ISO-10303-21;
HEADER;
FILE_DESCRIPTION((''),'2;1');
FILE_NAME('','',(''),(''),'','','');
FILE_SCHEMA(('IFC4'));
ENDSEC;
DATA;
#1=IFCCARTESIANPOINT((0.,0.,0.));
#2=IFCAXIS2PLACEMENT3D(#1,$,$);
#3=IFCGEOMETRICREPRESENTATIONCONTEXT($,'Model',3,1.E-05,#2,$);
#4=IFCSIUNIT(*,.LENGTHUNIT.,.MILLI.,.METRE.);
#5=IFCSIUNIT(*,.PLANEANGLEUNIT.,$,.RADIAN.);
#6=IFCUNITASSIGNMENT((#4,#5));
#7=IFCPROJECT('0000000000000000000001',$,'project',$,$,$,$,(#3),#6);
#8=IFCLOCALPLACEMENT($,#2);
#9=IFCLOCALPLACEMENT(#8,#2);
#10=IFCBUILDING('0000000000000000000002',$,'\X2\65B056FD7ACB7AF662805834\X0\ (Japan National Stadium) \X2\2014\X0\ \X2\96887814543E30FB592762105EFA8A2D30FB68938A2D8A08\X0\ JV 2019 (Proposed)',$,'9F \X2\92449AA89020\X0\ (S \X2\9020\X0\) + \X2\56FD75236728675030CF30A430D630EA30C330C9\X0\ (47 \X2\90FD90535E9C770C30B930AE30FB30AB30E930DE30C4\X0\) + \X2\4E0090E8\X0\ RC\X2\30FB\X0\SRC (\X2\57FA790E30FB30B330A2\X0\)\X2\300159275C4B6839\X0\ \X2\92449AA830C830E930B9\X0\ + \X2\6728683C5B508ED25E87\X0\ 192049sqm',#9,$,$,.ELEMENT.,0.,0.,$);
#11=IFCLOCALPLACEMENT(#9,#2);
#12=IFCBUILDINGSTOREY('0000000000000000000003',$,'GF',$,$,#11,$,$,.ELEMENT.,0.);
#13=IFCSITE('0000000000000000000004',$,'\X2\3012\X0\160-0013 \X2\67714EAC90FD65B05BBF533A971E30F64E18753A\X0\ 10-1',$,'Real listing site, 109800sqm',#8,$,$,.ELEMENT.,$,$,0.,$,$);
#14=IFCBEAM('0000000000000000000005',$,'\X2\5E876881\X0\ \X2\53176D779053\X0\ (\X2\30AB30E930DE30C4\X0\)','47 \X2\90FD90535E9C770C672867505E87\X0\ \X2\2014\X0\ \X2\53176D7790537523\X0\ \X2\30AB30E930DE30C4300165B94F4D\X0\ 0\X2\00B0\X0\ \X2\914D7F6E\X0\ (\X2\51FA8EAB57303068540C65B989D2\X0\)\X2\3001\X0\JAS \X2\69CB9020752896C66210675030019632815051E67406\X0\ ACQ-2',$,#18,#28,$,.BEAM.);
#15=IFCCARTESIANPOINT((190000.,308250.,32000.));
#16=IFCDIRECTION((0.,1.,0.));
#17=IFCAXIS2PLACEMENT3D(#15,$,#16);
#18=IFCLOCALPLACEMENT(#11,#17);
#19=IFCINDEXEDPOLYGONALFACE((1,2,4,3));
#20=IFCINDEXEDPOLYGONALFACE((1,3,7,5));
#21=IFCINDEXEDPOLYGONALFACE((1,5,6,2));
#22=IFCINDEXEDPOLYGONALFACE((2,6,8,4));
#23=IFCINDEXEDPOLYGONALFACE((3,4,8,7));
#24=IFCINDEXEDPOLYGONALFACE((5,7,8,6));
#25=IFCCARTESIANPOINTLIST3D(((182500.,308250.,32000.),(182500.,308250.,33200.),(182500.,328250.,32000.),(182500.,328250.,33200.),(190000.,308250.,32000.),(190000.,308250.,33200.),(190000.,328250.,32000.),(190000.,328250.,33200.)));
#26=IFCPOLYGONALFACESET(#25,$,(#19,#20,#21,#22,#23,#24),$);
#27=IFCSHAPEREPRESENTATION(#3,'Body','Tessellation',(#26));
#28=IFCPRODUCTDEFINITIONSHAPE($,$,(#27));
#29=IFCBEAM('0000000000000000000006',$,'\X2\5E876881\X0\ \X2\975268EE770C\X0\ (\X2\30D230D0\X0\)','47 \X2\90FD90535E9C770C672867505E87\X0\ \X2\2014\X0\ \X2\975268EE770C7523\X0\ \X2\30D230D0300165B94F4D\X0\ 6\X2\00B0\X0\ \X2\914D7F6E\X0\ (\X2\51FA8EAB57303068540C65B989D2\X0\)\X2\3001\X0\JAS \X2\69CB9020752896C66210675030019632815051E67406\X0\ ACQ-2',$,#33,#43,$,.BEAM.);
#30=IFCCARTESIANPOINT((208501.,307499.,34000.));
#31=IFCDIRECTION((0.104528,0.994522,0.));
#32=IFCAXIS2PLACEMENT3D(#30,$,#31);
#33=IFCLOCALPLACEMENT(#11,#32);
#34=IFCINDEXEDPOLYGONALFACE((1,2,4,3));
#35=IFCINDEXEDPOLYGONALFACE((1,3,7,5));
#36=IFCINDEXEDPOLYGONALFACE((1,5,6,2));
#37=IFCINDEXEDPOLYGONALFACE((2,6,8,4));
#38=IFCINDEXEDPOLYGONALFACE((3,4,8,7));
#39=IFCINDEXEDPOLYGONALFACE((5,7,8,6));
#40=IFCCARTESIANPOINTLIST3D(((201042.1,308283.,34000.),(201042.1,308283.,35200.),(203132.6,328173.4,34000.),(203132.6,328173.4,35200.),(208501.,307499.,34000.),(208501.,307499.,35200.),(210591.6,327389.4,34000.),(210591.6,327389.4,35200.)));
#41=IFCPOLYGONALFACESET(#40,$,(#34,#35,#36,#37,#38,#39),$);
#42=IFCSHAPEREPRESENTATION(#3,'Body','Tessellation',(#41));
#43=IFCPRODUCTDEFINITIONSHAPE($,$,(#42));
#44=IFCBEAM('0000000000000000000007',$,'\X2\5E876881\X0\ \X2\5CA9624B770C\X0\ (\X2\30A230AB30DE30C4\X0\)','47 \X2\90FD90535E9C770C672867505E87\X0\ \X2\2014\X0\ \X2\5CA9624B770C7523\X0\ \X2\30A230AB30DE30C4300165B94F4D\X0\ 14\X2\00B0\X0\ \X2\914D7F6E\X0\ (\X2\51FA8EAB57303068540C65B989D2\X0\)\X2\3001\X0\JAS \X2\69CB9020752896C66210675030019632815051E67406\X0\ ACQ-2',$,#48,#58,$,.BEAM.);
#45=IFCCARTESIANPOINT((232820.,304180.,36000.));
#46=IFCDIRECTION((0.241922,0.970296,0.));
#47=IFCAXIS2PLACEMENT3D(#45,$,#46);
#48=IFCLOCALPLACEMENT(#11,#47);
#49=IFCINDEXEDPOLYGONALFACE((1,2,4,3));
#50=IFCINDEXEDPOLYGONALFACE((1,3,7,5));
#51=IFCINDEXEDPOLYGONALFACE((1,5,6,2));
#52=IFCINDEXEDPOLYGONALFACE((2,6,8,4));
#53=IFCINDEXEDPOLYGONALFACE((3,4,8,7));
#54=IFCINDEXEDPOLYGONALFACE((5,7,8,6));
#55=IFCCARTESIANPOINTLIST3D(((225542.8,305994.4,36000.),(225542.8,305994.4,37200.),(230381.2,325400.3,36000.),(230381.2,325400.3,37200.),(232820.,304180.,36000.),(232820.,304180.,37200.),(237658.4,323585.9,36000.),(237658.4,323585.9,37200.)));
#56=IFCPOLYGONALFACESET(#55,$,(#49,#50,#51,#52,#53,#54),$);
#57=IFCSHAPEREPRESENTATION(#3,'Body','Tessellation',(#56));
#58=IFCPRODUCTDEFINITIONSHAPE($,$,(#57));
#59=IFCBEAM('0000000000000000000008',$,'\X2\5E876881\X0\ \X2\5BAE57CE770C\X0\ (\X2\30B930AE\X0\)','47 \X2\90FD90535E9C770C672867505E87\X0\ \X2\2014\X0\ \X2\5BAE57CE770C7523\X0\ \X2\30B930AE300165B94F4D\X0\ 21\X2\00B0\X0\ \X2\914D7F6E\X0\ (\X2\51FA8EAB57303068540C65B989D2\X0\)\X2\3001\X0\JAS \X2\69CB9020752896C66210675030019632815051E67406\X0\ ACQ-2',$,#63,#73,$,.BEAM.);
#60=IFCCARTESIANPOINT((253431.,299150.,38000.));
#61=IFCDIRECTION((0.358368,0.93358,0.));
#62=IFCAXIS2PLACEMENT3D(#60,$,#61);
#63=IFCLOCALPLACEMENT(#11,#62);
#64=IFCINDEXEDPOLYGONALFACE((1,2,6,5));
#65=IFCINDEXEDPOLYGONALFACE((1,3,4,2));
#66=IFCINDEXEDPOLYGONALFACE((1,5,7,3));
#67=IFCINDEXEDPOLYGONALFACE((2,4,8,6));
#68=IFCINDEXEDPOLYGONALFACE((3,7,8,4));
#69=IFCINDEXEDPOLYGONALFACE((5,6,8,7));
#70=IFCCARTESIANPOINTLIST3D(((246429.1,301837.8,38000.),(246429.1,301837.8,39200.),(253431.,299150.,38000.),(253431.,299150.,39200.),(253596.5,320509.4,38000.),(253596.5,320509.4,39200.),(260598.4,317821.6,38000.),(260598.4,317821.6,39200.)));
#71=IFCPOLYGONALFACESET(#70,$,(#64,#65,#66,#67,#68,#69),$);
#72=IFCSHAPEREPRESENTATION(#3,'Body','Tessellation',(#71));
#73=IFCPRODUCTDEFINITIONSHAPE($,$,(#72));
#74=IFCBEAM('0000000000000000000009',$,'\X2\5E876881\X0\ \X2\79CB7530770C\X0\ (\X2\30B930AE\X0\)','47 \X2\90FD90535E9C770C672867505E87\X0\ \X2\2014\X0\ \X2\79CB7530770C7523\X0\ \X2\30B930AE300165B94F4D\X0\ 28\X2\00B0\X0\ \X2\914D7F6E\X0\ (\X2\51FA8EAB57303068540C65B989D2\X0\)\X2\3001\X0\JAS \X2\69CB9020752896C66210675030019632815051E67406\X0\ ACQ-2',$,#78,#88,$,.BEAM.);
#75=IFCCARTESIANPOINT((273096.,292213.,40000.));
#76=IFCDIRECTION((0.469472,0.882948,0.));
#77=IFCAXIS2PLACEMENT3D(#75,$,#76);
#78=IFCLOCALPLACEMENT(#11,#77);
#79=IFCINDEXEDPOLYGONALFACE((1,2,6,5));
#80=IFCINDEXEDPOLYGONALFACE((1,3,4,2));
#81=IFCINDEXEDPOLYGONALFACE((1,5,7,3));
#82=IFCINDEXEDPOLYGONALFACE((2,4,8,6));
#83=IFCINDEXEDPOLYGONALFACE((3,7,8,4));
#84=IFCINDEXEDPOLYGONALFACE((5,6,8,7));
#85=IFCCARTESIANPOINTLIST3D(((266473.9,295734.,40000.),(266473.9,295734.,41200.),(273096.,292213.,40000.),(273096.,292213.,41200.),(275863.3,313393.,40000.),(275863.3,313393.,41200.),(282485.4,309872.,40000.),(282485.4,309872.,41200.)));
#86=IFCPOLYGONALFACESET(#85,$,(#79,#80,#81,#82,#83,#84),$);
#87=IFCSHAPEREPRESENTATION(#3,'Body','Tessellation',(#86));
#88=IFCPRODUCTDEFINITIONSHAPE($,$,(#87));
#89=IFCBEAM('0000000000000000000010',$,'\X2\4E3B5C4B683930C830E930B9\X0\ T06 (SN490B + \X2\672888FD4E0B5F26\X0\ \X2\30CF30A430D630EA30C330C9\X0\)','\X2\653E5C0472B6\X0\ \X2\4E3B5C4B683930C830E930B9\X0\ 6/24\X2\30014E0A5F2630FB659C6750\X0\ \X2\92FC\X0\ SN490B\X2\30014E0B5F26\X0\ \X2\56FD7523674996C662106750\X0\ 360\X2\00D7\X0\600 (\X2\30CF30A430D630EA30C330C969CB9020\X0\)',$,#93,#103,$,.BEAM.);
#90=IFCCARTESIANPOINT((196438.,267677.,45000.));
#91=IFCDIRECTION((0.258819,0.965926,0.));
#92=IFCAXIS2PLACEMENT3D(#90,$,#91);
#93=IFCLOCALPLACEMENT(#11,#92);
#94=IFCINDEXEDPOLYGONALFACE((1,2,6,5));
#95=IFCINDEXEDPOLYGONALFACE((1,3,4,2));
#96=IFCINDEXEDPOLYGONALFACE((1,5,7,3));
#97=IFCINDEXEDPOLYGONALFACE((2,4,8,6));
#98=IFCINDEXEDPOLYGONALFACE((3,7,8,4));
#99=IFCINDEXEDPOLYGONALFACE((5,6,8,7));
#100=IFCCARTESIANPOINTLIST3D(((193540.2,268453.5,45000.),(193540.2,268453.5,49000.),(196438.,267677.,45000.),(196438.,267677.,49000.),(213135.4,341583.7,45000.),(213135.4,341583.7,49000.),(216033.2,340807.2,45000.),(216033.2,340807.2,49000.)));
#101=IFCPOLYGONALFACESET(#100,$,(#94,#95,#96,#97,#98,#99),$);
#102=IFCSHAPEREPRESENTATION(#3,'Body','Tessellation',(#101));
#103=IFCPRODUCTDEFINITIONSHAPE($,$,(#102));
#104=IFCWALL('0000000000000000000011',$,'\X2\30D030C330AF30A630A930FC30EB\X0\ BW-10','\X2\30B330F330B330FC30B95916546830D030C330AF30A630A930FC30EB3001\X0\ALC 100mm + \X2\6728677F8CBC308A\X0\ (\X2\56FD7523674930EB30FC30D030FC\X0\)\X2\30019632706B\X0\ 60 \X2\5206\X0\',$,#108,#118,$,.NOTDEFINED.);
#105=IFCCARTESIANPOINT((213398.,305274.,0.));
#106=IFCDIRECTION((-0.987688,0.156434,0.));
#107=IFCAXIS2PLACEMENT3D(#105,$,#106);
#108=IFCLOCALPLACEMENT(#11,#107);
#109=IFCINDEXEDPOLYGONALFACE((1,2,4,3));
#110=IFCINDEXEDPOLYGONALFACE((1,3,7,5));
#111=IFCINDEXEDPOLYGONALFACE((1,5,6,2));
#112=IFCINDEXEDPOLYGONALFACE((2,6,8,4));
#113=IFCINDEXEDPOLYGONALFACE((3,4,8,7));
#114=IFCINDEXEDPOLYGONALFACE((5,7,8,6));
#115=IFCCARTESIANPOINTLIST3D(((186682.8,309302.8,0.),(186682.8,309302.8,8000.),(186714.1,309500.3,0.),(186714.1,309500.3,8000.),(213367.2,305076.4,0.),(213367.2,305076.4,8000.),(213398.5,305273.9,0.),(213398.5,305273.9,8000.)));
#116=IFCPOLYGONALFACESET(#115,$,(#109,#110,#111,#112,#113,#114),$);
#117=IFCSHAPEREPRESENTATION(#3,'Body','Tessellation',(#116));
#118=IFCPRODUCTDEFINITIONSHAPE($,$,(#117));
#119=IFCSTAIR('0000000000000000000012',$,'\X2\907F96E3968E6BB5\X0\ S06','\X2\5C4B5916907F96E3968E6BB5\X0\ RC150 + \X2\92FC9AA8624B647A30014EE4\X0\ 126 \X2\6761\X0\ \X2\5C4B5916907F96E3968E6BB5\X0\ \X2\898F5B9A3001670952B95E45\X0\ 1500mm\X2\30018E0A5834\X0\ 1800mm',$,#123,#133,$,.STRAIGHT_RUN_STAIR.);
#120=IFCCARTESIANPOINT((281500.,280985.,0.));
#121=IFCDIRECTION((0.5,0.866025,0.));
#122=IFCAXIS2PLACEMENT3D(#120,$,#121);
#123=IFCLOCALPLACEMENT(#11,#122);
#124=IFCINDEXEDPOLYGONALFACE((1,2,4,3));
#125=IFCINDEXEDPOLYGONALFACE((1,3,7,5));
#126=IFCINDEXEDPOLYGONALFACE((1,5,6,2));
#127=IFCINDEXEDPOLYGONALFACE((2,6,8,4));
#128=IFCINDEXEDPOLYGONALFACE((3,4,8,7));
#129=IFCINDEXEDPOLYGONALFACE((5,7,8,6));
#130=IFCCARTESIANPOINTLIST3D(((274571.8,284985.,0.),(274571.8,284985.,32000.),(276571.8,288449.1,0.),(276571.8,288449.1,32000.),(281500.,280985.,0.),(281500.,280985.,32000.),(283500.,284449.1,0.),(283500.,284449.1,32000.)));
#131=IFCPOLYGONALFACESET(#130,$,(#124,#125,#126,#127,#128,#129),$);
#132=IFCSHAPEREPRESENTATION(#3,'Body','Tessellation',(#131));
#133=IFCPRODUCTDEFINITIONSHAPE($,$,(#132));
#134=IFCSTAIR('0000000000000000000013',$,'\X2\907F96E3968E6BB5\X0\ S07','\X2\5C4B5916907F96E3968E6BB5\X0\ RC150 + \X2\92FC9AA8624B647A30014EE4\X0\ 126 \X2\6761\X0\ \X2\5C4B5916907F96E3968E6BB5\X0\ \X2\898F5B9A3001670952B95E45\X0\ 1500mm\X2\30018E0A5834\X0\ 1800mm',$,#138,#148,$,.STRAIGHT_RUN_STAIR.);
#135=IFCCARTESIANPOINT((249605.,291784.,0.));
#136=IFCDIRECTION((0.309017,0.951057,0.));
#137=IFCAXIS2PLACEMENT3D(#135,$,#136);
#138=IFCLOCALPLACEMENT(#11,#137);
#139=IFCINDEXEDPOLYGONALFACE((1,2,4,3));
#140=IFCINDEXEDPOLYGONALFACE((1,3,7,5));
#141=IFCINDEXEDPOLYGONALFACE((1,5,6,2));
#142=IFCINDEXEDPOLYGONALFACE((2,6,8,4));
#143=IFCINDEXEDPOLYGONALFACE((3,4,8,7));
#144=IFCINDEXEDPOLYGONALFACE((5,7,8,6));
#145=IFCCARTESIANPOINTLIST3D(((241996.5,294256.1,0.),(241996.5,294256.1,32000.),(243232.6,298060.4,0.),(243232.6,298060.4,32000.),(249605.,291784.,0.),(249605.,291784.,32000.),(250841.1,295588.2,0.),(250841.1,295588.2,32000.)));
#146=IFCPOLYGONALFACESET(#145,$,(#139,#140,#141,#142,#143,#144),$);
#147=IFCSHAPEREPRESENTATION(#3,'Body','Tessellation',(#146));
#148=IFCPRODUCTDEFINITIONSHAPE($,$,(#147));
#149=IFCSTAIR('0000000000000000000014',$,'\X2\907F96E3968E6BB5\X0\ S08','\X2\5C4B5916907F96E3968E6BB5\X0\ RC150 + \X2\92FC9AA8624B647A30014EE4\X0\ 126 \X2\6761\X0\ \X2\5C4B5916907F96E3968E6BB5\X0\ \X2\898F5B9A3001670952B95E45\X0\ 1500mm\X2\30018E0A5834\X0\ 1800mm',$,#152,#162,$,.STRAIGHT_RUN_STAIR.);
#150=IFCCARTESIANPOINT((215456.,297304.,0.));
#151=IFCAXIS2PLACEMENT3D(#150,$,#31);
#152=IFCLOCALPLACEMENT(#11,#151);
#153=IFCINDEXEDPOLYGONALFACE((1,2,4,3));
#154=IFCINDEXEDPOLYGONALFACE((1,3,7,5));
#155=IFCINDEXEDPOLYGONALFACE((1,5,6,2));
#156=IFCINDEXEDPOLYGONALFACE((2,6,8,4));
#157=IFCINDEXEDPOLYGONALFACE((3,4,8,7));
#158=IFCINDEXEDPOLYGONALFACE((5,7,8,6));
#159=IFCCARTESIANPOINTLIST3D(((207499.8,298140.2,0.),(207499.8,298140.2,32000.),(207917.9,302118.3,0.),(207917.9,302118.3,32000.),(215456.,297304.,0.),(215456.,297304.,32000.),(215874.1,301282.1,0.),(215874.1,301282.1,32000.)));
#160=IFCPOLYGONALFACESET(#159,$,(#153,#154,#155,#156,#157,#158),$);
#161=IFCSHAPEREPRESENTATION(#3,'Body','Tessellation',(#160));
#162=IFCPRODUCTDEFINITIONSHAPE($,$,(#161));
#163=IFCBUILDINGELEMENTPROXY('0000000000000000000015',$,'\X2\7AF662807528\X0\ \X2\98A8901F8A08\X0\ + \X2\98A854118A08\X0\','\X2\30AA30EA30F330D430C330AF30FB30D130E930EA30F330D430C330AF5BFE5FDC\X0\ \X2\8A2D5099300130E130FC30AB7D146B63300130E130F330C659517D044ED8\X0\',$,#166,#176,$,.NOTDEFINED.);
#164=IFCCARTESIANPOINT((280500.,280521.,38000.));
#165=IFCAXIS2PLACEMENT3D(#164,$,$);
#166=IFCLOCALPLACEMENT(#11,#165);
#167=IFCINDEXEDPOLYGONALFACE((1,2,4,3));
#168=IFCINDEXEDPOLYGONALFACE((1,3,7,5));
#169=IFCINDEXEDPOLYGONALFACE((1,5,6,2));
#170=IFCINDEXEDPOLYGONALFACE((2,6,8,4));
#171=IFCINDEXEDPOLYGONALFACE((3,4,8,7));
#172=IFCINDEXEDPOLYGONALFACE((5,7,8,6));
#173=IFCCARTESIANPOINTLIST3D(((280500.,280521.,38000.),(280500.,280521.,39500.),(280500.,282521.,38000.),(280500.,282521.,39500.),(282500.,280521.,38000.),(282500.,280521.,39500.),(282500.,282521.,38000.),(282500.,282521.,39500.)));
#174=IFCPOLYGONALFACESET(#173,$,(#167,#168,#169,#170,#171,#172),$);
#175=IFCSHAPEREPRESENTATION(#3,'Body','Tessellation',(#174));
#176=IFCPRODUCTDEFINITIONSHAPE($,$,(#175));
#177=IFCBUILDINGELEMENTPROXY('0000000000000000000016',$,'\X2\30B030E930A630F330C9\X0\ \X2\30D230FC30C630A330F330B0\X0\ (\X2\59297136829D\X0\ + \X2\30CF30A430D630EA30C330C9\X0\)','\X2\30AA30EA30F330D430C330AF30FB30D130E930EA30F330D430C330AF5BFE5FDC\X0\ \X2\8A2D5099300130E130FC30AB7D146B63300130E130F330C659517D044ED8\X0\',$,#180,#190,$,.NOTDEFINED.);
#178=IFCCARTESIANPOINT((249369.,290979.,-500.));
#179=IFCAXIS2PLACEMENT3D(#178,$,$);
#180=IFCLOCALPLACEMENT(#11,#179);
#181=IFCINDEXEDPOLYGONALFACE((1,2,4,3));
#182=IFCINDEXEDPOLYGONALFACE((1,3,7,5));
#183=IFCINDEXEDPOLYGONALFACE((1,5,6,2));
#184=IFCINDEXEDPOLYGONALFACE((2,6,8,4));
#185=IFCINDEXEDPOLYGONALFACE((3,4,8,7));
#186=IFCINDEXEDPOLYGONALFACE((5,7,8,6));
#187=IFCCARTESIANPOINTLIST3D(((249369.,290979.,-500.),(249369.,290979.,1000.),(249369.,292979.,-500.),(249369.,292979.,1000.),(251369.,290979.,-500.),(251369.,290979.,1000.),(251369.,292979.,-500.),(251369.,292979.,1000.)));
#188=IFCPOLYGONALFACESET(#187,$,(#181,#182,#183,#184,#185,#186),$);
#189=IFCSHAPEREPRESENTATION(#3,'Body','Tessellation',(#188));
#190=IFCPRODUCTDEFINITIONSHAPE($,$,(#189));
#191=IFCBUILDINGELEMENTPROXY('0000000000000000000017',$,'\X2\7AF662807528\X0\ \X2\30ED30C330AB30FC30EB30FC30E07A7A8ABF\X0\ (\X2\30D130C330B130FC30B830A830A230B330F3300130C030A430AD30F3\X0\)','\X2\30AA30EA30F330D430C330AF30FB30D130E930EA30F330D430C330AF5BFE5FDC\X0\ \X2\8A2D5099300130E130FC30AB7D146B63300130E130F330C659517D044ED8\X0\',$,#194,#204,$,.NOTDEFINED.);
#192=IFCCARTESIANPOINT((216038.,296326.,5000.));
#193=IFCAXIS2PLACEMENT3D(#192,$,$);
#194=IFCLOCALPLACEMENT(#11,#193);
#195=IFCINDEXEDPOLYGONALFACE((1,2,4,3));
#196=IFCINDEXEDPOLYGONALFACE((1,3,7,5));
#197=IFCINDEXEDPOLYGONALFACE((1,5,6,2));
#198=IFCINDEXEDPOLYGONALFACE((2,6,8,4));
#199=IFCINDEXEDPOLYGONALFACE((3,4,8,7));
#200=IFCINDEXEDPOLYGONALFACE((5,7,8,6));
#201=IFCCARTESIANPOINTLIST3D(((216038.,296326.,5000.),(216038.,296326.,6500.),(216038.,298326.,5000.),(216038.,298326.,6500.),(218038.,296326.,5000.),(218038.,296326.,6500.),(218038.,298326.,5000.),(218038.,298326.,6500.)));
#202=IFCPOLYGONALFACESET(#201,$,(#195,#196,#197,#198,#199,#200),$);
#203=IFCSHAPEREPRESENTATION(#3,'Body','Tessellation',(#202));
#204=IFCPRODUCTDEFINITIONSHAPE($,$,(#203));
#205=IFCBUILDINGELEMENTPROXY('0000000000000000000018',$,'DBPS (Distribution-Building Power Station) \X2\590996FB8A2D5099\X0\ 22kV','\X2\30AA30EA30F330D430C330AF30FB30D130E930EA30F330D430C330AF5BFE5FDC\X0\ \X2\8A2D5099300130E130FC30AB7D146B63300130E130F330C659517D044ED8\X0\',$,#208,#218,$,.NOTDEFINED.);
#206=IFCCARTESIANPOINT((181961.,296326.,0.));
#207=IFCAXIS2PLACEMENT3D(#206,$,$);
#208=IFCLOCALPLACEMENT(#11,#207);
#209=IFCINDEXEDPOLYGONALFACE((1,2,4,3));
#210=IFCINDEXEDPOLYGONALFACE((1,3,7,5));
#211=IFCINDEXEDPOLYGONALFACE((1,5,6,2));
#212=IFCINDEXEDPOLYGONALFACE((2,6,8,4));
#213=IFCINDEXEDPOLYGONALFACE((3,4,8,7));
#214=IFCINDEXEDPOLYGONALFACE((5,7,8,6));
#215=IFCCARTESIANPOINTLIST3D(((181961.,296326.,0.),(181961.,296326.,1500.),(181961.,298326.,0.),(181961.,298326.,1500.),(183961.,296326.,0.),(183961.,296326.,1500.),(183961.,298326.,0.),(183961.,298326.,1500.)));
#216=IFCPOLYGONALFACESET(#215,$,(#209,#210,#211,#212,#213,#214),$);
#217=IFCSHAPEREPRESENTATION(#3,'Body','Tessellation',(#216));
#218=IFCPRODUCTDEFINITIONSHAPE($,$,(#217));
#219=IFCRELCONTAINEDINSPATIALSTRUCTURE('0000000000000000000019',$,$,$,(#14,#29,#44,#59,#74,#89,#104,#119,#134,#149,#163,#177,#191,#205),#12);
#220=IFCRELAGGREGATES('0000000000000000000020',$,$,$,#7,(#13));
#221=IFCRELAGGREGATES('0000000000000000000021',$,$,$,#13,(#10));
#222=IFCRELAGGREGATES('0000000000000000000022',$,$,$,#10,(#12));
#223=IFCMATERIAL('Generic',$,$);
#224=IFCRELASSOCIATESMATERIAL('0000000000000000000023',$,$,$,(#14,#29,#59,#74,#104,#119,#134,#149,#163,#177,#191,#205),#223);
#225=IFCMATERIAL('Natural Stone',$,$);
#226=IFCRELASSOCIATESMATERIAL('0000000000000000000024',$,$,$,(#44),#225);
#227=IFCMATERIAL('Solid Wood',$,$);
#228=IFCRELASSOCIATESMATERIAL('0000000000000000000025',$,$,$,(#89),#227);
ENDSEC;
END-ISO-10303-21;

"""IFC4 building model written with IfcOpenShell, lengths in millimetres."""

from ifc_helpers import new_model, si_unit, frame, frame_2d, origin, place, context, project, spatial, rectangle, extrude, material, element, save


model = new_model("IFC4")

# Units and contexts
model_context = context("Model", 3, precision=1e-05, world=origin())
ifc_project = project(units=[si_unit("LENGTHUNIT", "METRE", prefix="MILLI"), si_unit("PLANEANGLEUNIT", "RADIAN")], contexts=[model_context])

# Site, building, storey
site_placement = place(None, origin())
site = spatial("IfcSite", under=ifc_project, at=site_placement, Name="〒160-0013 東京都新宿区霞ヶ丘町 10-1", ObjectType="Real listing site, 109800sqm", CompositionType="ELEMENT", RefElevation=0.0)
building_placement = place(site_placement, origin())
building = spatial("IfcBuilding", under=site, at=building_placement, Name="新国立競技場 (Japan National Stadium) — 隈研吾・大成建設・梓設計 JV 2019 (Proposed)", ObjectType="9F 鉄骨造 (S 造) + 国産木材ハイブリッド (47 都道府県スギ・カラマツ) + 一部 RC・SRC (基礎・コア)、大屋根 鉄骨トラス + 木格子軒庇 192049sqm", CompositionType="ELEMENT", ElevationOfRefHeight=0.0, ElevationOfTerrain=0.0)
storey_placement = place(building_placement, origin())
storey = spatial("IfcBuildingStorey", under=building, at=storey_placement, Name="GF", CompositionType="ELEMENT", Elevation=0.0)

# Shared definitions
ifc_material_1 = material(Name="Generic")

# Beams
beam_1_placement = place(storey_placement, frame((190000.0, 308250.0, 32000.0), x_axis=(0.0, 1.0, 0.0)))
element("IfcBeam", 1, at=beam_1_placement, inside=storey, material=ifc_material_1, Name="庇梁 北海道 (カラマツ)", Description="47 都道府県木材庇 — 北海道産 カラマツ、方位 0° 配置 (出身地と同方角)、JAS 構造用集成材、防腐処理 ACQ-2", PredefinedType="BEAM", context=model_context, shape_type="SweptSolid", body=[
    extrude(rectangle(XDim=20000.0, YDim=7500.0, at=frame_2d((10000.0, 3750.0))), frame((190000.0, 308250.0, 32000.0), x_axis=(0.0, 1.0, 0.0)), (0.0, 0.0, 1.0), 1200.0),
])
beam_2_placement = place(storey_placement, frame((208501.0, 307499.0, 34000.0), x_axis=(0.104528, 0.994522, 0.0)))
element("IfcBeam", 2, at=beam_2_placement, inside=storey, material=ifc_material_1, Name="庇梁 青森県 (ヒバ)", Description="47 都道府県木材庇 — 青森県産 ヒバ、方位 6° 配置 (出身地と同方角)、JAS 構造用集成材、防腐処理 ACQ-2", PredefinedType="BEAM", context=model_context, shape_type="SweptSolid", body=[
    extrude(rectangle(XDim=20000.0, YDim=7500.0, at=frame_2d((10000.0, 3750.0))), frame((208501.0, 307499.0, 34000.0), x_axis=(0.104528, 0.994522, 0.0)), (0.0, 0.0, 1.0), 1200.0),
])
ifc_material_2 = material(Name="Natural Stone")
beam_3_placement = place(storey_placement, frame((232820.0, 304180.0, 36000.0), x_axis=(0.241922, 0.970296, 0.0)))
element("IfcBeam", 3, at=beam_3_placement, inside=storey, material=ifc_material_2, Name="庇梁 岩手県 (アカマツ)", Description="47 都道府県木材庇 — 岩手県産 アカマツ、方位 14° 配置 (出身地と同方角)、JAS 構造用集成材、防腐処理 ACQ-2", PredefinedType="BEAM", context=model_context, shape_type="SweptSolid", body=[
    extrude(rectangle(XDim=20000.0, YDim=7500.0, at=frame_2d((10000.0, 3750.0))), frame((232820.0, 304180.0, 36000.0), x_axis=(0.241922, 0.970296, 0.0)), (0.0, 0.0, 1.0), 1200.0),
])
beam_4_placement = place(storey_placement, frame((253431.0, 299150.0, 38000.0), x_axis=(0.358368, 0.93358, 0.0)))
element("IfcBeam", 4, at=beam_4_placement, inside=storey, material=ifc_material_1, Name="庇梁 宮城県 (スギ)", Description="47 都道府県木材庇 — 宮城県産 スギ、方位 21° 配置 (出身地と同方角)、JAS 構造用集成材、防腐処理 ACQ-2", PredefinedType="BEAM", context=model_context, shape_type="SweptSolid", body=[
    extrude(rectangle(XDim=20000.0, YDim=7500.0, at=frame_2d((10000.0, 3750.0))), frame((253431.0, 299150.0, 38000.0), x_axis=(0.358368, 0.93358, 0.0)), (0.0, 0.0, 1.0), 1200.0),
])
beam_5_placement = place(storey_placement, frame((273096.0, 292213.0, 40000.0), x_axis=(0.469472, 0.882948, 0.0)))
element("IfcBeam", 5, at=beam_5_placement, inside=storey, material=ifc_material_1, Name="庇梁 秋田県 (スギ)", Description="47 都道府県木材庇 — 秋田県産 スギ、方位 28° 配置 (出身地と同方角)、JAS 構造用集成材、防腐処理 ACQ-2", PredefinedType="BEAM", context=model_context, shape_type="SweptSolid", body=[
    extrude(rectangle(XDim=20000.0, YDim=7500.0, at=frame_2d((10000.0, 3750.0))), frame((273096.0, 292213.0, 40000.0), x_axis=(0.469472, 0.882948, 0.0)), (0.0, 0.0, 1.0), 1200.0),
])
ifc_material_3 = material(Name="Solid Wood")
beam_6_placement = place(storey_placement, frame((196438.0, 267677.0, 45000.0), x_axis=(0.258819, 0.965926, 0.0)))
element("IfcBeam", 6, at=beam_6_placement, inside=storey, material=ifc_material_3, Name="主屋根トラス T06 (SN490B + 木製下弦 ハイブリッド)", Description="放射状 主屋根トラス 6/24、上弦・斜材 鋼 SN490B、下弦 国産杉集成材 360×600 (ハイブリッド構造)", PredefinedType="BEAM", context=model_context, shape_type="SweptSolid", body=[
    extrude(rectangle(XDim=75710.0, YDim=3000.0, at=frame_2d((37855.0, 1500.0))), frame((196438.0, 267677.0, 45000.0), x_axis=(0.258819, 0.965926, 0.0)), (0.0, 0.0, 1.0), 4000.0),
])

# Wall
wall_1_placement = place(storey_placement, frame((213398.0, 305274.0, 0.0), x_axis=(-0.987688, 0.156434, 0.0)))
element("IfcWall", 7, at=wall_1_placement, inside=storey, material=ifc_material_1, Name="バックウォール BW-10", Description="コンコース外周バックウォール、ALC 100mm + 木板貼り (国産杉ルーバー)、防火 60 分", PredefinedType="NOTDEFINED", context=model_context, shape_type="SweptSolid", body=[
    extrude(rectangle(XDim=27017.0, YDim=200.0, at=frame_2d((13508.0, 100.0))), frame((213398.0, 305274.0, 0.0), x_axis=(-0.987688, 0.156434, 0.0)), (0.0, 0.0, 1.0), 8000.0),
])

# Stairs
stair_1_placement = place(storey_placement, frame((281500.0, 280985.0, 0.0), x_axis=(0.5, 0.866025, 0.0)))
element("IfcStair", 8, at=stair_1_placement, inside=storey, material=ifc_material_1, Name="避難階段 S06", Description="屋外避難階段 RC150 + 鋼骨手摺、令 126 条 屋外避難階段 規定、有効幅 1500mm、踊場 1800mm", PredefinedType="STRAIGHT_RUN_STAIR", context=model_context, shape_type="SweptSolid", body=[
    extrude(rectangle(XDim=4000.0, YDim=8000.0, at=frame_2d((2000.0, 4000.0))), frame((281500.0, 280985.0, 0.0), x_axis=(0.5, 0.866025, 0.0)), (0.0, 0.0, 1.0), 32000.0),
])
stair_2_placement = place(storey_placement, frame((249605.0, 291784.0, 0.0), x_axis=(0.309017, 0.951057, 0.0)))
element("IfcStair", 9, at=stair_2_placement, inside=storey, material=ifc_material_1, Name="避難階段 S07", Description="屋外避難階段 RC150 + 鋼骨手摺、令 126 条 屋外避難階段 規定、有効幅 1500mm、踊場 1800mm", PredefinedType="STRAIGHT_RUN_STAIR", context=model_context, shape_type="SweptSolid", body=[
    extrude(rectangle(XDim=4000.0, YDim=8000.0, at=frame_2d((2000.0, 4000.0))), frame((249605.0, 291784.0, 0.0), x_axis=(0.309017, 0.951057, 0.0)), (0.0, 0.0, 1.0), 32000.0),
])
stair_3_placement = place(storey_placement, frame((215456.0, 297304.0, 0.0), x_axis=(0.104528, 0.994522, 0.0)))
element("IfcStair", 10, at=stair_3_placement, inside=storey, material=ifc_material_1, Name="避難階段 S08", Description="屋外避難階段 RC150 + 鋼骨手摺、令 126 条 屋外避難階段 規定、有効幅 1500mm、踊場 1800mm", PredefinedType="STRAIGHT_RUN_STAIR", context=model_context, shape_type="SweptSolid", body=[
    extrude(rectangle(XDim=4000.0, YDim=8000.0, at=frame_2d((2000.0, 4000.0))), frame((215456.0, 297304.0, 0.0), x_axis=(0.104528, 0.994522, 0.0)), (0.0, 0.0, 1.0), 32000.0),
])

# Building element proxies
proxy_1_placement = place(storey_placement, frame((280500.0, 280521.0, 38000.0)))
element("IfcBuildingElementProxy", 11, at=proxy_1_placement, inside=storey, material=ifc_material_1, Name="競技用 風速計 + 風向計", Description="オリンピック・パラリンピック対応 設備、メーカ純正、メンテ契約付", PredefinedType="NOTDEFINED", context=model_context, shape_type="SweptSolid", body=[
    extrude(rectangle(XDim=2000.0, YDim=2000.0, at=frame_2d((1000.0, 1000.0))), frame((280500.0, 280521.0, 38000.0)), (0.0, 0.0, 1.0), 1500.0),
])
proxy_2_placement = place(storey_placement, frame((249369.0, 290979.0, -500.0)))
element("IfcBuildingElementProxy", 12, at=proxy_2_placement, inside=storey, material=ifc_material_1, Name="グラウンド ヒーティング (天然芝 + ハイブリッド)", Description="オリンピック・パラリンピック対応 設備、メーカ純正、メンテ契約付", PredefinedType="NOTDEFINED", context=model_context, shape_type="SweptSolid", body=[
    extrude(rectangle(XDim=2000.0, YDim=2000.0, at=frame_2d((1000.0, 1000.0))), frame((249369.0, 290979.0, -500.0)), (0.0, 0.0, 1.0), 1500.0),
])
proxy_3_placement = place(storey_placement, frame((216038.0, 296326.0, 5000.0)))
element("IfcBuildingElementProxy", 13, at=proxy_3_placement, inside=storey, material=ifc_material_1, Name="競技用 ロッカールーム空調 (パッケージエアコン、ダイキン)", Description="オリンピック・パラリンピック対応 設備、メーカ純正、メンテ契約付", PredefinedType="NOTDEFINED", context=model_context, shape_type="SweptSolid", body=[
    extrude(rectangle(XDim=2000.0, YDim=2000.0, at=frame_2d((1000.0, 1000.0))), frame((216038.0, 296326.0, 5000.0)), (0.0, 0.0, 1.0), 1500.0),
])
proxy_4_placement = place(storey_placement, frame((181961.0, 296326.0, 0.0)))
element("IfcBuildingElementProxy", 14, at=proxy_4_placement, inside=storey, material=ifc_material_1, Name="DBPS (Distribution-Building Power Station) 変電設備 22kV", Description="オリンピック・パラリンピック対応 設備、メーカ純正、メンテ契約付", PredefinedType="NOTDEFINED", context=model_context, shape_type="SweptSolid", body=[
    extrude(rectangle(XDim=2000.0, YDim=2000.0, at=frame_2d((1000.0, 1000.0))), frame((181961.0, 296326.0, 0.0)), (0.0, 0.0, 1.0), 1500.0),
])

save(model, "model.ifc")
